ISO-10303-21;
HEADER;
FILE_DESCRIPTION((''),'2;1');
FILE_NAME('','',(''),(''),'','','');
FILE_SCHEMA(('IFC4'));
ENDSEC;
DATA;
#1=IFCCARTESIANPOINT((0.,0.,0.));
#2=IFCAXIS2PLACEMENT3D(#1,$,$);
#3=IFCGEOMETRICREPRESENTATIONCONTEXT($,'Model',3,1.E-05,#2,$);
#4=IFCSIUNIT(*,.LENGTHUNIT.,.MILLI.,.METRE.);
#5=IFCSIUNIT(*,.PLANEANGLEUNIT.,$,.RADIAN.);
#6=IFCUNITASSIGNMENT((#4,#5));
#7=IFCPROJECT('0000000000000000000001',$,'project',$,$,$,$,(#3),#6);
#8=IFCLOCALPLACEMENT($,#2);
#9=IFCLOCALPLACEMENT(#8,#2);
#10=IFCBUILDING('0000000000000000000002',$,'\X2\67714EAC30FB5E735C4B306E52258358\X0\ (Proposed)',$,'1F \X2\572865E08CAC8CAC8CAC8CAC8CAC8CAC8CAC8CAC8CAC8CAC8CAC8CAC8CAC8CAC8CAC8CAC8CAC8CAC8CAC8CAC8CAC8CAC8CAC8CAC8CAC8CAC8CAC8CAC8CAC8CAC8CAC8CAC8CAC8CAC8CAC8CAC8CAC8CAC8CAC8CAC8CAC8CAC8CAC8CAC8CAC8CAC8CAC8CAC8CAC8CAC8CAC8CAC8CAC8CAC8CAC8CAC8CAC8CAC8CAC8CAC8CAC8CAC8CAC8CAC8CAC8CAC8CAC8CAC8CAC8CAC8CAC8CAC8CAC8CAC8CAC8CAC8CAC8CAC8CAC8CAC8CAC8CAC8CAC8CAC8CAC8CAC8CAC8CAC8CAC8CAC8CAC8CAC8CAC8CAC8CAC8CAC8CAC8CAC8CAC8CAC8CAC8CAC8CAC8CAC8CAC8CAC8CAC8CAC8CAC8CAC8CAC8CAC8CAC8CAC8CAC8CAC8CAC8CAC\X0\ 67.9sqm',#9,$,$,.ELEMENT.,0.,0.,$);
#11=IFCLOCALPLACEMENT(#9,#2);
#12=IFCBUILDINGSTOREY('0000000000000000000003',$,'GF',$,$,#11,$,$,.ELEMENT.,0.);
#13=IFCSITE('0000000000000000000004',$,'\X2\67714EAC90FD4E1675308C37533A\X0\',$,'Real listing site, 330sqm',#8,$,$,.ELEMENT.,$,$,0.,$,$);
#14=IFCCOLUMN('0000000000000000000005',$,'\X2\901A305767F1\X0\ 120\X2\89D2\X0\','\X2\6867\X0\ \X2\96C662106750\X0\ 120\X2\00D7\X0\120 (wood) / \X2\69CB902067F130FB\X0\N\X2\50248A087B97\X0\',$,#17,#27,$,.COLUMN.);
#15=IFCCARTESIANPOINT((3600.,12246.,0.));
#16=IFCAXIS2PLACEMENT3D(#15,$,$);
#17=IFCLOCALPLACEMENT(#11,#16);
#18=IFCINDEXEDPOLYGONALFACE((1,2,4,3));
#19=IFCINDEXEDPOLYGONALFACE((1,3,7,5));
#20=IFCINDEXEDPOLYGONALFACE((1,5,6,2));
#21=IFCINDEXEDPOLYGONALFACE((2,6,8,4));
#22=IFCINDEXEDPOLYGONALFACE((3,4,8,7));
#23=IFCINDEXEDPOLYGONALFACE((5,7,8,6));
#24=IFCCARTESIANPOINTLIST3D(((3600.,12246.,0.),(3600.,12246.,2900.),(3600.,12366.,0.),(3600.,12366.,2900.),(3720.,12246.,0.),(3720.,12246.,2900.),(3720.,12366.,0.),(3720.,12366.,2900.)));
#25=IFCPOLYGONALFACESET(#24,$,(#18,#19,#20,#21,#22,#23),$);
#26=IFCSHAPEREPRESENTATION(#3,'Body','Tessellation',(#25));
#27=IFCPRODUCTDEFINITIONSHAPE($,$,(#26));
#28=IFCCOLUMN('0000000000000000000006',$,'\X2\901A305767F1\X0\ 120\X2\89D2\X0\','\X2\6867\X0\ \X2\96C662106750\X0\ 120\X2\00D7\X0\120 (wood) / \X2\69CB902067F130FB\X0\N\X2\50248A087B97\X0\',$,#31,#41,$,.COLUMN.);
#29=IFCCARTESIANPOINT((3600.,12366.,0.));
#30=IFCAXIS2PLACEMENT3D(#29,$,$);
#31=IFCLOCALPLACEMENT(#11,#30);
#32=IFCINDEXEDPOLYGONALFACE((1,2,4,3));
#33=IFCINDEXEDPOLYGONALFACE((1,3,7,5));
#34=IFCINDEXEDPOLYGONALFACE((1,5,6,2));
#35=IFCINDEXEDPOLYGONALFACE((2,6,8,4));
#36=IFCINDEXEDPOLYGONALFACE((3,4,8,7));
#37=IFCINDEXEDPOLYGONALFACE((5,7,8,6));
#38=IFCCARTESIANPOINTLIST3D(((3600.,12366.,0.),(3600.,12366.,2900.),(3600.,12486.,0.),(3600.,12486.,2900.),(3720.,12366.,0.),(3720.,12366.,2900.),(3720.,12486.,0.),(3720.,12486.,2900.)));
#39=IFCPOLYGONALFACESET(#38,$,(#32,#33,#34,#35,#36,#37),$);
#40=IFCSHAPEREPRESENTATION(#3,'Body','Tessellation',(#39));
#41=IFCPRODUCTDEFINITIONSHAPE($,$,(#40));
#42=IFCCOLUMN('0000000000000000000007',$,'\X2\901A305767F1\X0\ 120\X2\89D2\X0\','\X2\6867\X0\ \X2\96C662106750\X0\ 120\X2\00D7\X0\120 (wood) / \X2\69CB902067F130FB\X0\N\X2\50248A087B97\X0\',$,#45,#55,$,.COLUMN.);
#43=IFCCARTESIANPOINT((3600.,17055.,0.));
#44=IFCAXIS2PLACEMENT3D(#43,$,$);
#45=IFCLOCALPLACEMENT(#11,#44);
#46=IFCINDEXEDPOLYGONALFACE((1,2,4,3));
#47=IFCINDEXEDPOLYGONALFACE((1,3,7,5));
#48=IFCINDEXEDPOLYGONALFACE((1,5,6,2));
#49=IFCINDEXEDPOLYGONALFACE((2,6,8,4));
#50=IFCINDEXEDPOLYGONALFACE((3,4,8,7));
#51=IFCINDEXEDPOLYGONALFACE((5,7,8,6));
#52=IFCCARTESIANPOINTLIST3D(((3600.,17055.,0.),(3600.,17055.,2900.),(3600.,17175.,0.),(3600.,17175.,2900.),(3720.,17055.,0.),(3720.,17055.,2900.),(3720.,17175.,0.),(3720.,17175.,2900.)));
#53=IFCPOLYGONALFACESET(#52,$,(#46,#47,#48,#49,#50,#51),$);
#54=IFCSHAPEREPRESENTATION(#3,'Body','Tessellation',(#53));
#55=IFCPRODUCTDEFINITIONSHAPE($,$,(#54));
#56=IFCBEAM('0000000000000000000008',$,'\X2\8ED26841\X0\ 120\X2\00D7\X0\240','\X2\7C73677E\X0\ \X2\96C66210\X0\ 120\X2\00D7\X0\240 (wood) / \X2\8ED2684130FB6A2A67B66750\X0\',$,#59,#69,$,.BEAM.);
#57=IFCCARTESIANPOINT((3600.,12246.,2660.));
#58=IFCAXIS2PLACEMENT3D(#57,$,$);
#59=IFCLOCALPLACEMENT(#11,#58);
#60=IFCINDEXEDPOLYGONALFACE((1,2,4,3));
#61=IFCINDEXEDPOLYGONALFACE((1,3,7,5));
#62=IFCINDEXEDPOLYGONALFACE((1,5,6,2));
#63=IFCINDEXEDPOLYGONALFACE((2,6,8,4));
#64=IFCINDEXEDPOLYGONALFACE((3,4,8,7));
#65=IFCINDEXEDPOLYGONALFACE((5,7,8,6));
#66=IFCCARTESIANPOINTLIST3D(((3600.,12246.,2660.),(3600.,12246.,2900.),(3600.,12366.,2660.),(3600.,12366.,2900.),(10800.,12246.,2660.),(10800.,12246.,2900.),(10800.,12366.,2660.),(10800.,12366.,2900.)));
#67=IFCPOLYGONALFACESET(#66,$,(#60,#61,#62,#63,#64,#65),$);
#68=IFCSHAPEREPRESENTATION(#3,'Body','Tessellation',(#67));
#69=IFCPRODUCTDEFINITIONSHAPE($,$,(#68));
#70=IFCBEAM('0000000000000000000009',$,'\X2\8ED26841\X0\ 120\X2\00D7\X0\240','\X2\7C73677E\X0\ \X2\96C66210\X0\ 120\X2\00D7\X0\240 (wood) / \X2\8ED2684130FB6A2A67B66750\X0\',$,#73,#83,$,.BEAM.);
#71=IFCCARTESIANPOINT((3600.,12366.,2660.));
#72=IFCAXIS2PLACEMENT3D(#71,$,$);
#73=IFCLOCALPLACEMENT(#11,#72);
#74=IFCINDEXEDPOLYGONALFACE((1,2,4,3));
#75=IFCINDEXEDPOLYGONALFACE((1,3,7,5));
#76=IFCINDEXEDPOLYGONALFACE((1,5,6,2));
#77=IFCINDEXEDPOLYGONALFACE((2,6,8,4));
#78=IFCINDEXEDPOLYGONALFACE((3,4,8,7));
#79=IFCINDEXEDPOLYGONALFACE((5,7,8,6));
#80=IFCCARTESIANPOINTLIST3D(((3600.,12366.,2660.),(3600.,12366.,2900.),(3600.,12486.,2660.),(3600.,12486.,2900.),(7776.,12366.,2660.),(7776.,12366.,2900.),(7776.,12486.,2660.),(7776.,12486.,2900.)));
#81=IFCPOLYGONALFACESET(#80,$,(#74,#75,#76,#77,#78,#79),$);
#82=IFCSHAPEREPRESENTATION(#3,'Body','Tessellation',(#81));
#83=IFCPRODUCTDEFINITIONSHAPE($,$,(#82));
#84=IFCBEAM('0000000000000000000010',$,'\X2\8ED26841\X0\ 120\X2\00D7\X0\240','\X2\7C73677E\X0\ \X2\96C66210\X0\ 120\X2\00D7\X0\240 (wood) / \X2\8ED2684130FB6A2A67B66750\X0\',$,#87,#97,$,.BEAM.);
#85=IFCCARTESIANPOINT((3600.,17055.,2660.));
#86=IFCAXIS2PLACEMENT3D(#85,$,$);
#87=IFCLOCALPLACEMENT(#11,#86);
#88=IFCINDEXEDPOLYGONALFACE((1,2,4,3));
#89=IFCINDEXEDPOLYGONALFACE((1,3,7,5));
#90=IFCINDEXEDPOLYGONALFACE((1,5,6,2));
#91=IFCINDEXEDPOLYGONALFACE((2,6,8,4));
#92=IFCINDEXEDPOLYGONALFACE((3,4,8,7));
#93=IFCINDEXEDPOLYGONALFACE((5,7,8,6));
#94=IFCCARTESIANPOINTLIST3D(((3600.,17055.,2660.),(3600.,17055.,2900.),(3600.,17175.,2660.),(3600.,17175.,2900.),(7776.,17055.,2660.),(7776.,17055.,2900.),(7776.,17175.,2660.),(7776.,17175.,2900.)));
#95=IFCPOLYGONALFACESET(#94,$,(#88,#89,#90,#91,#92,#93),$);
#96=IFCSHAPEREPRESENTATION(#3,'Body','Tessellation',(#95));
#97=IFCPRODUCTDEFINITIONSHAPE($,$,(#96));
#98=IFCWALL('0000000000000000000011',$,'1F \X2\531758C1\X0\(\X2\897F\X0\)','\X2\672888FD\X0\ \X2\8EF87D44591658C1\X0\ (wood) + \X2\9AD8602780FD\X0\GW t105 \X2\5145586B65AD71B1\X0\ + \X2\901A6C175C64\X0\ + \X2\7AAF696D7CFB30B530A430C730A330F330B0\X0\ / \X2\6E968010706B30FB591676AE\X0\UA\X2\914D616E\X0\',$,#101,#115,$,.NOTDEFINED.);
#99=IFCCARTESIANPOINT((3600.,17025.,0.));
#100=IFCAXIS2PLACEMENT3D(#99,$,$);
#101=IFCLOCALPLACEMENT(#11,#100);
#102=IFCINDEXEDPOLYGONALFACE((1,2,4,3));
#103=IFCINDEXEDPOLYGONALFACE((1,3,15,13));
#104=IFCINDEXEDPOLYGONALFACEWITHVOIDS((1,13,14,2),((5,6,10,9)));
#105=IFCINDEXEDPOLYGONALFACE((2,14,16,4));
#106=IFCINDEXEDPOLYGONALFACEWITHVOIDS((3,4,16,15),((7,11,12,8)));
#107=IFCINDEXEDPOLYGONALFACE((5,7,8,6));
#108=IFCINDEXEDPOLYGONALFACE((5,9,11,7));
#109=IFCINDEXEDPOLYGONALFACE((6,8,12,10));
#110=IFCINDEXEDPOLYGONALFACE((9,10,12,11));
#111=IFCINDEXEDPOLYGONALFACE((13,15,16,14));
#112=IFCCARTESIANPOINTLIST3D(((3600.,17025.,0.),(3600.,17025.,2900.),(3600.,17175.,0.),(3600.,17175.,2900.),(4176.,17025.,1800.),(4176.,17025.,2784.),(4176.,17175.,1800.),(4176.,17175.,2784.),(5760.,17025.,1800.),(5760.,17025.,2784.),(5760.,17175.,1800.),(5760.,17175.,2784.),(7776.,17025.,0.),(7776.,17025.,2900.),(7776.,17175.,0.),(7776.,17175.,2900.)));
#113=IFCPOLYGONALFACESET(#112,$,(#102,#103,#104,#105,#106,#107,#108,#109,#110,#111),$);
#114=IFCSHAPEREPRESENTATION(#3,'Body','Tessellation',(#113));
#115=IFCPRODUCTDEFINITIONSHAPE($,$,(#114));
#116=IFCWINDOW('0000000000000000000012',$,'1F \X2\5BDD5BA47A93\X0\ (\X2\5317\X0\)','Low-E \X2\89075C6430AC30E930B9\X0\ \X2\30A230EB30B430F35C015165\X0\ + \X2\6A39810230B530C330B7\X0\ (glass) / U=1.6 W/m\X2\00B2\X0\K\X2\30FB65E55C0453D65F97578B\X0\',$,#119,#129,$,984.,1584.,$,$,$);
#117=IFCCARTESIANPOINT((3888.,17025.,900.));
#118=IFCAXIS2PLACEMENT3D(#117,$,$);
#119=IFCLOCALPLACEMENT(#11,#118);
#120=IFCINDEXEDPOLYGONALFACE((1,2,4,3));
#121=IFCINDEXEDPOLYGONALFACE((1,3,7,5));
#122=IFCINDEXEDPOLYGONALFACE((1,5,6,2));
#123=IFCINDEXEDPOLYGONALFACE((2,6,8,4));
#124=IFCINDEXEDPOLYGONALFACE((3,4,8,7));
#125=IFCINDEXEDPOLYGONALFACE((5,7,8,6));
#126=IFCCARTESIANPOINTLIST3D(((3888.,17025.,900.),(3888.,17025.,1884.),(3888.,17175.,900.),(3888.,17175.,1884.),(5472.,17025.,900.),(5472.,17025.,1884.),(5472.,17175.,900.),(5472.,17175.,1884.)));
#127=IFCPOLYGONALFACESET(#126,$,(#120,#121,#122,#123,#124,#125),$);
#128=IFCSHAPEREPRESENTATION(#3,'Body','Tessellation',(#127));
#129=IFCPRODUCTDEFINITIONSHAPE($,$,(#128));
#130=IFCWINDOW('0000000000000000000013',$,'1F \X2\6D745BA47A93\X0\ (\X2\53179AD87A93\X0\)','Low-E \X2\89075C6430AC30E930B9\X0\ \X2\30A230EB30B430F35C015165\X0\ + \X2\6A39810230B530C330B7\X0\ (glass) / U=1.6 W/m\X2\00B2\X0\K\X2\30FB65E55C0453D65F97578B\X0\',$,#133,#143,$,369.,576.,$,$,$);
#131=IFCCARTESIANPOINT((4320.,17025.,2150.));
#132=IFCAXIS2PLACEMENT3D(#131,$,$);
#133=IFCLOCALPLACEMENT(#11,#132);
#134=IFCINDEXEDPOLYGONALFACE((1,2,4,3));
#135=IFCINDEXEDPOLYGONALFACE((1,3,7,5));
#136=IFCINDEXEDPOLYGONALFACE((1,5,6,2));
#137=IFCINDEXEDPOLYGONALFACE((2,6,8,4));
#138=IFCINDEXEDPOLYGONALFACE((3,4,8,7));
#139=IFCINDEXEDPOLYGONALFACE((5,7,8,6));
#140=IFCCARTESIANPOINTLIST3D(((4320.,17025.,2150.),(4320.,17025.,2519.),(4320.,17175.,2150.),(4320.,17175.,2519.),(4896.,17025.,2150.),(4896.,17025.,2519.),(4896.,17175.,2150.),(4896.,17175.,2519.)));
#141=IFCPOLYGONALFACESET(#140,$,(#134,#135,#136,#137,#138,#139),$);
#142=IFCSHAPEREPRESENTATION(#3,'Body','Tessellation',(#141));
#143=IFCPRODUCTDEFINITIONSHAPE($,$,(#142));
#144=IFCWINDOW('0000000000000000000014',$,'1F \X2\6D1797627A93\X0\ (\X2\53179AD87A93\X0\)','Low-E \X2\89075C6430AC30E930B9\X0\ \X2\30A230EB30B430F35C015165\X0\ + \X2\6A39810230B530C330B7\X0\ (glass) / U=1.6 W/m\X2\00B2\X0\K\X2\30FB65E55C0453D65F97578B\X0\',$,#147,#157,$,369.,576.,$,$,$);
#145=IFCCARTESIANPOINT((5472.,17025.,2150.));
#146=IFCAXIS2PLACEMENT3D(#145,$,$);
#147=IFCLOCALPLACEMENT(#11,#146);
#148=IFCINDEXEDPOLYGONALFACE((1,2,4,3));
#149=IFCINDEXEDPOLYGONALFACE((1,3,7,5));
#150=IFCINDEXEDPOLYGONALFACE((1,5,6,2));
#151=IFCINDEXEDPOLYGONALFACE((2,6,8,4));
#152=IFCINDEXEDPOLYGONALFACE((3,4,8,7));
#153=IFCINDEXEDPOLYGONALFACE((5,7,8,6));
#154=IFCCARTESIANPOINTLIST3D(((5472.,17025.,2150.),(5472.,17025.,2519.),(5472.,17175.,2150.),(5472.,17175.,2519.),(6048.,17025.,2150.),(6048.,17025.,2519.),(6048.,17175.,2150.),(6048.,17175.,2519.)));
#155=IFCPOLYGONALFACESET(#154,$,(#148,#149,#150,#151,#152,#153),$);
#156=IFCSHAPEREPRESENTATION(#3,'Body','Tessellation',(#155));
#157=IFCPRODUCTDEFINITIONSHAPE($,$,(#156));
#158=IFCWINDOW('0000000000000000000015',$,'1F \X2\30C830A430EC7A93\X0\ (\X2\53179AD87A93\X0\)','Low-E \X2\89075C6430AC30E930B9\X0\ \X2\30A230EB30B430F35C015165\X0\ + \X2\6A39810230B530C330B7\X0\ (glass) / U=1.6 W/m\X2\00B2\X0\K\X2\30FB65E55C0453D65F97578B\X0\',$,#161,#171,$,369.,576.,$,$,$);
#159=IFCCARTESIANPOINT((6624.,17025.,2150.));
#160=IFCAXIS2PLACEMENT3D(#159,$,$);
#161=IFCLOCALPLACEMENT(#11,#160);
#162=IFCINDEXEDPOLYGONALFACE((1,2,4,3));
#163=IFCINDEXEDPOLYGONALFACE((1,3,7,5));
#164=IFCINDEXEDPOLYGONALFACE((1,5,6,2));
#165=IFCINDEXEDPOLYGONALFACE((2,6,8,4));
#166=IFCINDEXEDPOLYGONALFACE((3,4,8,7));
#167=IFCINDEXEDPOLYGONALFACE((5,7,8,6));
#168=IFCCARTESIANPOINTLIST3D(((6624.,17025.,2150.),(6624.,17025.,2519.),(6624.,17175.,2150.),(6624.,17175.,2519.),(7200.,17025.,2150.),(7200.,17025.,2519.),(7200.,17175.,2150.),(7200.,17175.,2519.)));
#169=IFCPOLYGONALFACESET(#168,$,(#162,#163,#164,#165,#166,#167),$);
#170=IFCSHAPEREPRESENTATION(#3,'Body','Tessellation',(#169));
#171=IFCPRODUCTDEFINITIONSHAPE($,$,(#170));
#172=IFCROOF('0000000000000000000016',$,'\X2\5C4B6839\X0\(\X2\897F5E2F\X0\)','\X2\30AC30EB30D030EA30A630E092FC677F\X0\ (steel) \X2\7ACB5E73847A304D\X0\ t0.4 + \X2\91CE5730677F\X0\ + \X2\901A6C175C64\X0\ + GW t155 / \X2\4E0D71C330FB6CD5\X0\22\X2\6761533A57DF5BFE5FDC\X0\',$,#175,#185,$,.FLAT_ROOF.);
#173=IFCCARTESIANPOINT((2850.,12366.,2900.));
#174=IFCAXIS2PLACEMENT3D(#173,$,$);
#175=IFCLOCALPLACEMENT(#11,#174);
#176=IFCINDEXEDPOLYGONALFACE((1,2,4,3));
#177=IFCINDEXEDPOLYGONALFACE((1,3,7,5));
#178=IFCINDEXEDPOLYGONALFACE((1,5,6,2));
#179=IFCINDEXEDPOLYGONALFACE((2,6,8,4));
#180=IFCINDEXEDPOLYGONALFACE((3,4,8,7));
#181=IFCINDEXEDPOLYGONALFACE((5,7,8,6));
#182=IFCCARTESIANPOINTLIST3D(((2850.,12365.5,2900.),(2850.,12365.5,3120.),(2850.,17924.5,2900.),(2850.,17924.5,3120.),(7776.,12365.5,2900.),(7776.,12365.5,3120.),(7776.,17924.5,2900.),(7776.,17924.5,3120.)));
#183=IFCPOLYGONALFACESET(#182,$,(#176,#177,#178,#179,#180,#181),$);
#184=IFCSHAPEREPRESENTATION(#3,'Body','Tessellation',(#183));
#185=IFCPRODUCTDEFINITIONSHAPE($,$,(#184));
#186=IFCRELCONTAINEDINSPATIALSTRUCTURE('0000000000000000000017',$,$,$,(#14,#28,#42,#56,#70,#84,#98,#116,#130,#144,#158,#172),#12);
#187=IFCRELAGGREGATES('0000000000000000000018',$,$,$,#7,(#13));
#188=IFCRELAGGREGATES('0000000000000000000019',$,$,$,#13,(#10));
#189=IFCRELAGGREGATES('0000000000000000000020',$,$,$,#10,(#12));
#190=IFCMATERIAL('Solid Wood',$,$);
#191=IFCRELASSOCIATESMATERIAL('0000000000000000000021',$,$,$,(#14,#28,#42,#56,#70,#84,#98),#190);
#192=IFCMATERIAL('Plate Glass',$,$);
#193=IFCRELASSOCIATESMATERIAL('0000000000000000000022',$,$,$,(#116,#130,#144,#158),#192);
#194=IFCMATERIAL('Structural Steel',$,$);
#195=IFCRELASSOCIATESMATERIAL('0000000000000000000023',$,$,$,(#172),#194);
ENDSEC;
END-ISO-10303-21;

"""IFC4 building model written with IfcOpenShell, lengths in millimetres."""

from ifc_helpers import new_model, si_unit, frame, frame_2d, origin, place, context, project, spatial, rectangle, extrude, material, element, fill, save


model = new_model("IFC4")

# Units and contexts
model_context = context("Model", 3, precision=1e-05, world=origin())
ifc_project = project(units=[si_unit("LENGTHUNIT", "METRE", prefix="MILLI"), si_unit("PLANEANGLEUNIT", "RADIAN")], contexts=[model_context])

# Site, building, storey
site_placement = place(None, origin())
site = spatial("IfcSite", under=ifc_project, at=site_placement, Name="東京都世田谷区", ObjectType="Real listing site, 330sqm", CompositionType="ELEMENT", RefElevation=0.0)
building_placement = place(site_placement, origin())
building = spatial("IfcBuilding", under=site, at=building_placement, Name="東京・平屋の別荘 (Proposed)", ObjectType="1F 在无責責責責責責責責責責責責責責責責責責責責責責責責責責責責責責責責責責責責責責責責責責責責責責責責責責責責責責責責責責責責責責責責責責責責責責責責責責責責責責責責責責責責責責責責責責責責責責責責責責責責責責責責責責責責責責責責責責責責責責 67.9sqm", CompositionType="ELEMENT", ElevationOfRefHeight=0.0, ElevationOfTerrain=0.0)
storey_placement = place(building_placement, origin())
storey = spatial("IfcBuildingStorey", under=building, at=storey_placement, Name="GF", CompositionType="ELEMENT", Elevation=0.0)

# Columns
ifc_material_1 = material(Name="Solid Wood")
column_1_placement = place(storey_placement, frame((3600.0, 12246.0, 0.0)))
element("IfcColumn", 1, at=column_1_placement, inside=storey, material=ifc_material_1, Name="通し柱 120角", Description="桧 集成材 120×120 (wood) / 構造柱・N値計算", PredefinedType="COLUMN", context=model_context, shape_type="SweptSolid", body=[
    extrude(rectangle(XDim=120.0, YDim=120.0, at=frame_2d((60.0, 60.0))), frame((3600.0, 12246.0, 0.0)), (0.0, 0.0, 1.0), 2900.0),
])
column_2_placement = place(storey_placement, frame((3600.0, 12366.0, 0.0)))
element("IfcColumn", 2, at=column_2_placement, inside=storey, material=ifc_material_1, Name="通し柱 120角", Description="桧 集成材 120×120 (wood) / 構造柱・N値計算", PredefinedType="COLUMN", context=model_context, shape_type="SweptSolid", body=[
    extrude(rectangle(XDim=120.0, YDim=120.0, at=frame_2d((60.0, 60.0))), frame((3600.0, 12366.0, 0.0)), (0.0, 0.0, 1.0), 2900.0),
])
column_3_placement = place(storey_placement, frame((3600.0, 17055.0, 0.0)))
element("IfcColumn", 3, at=column_3_placement, inside=storey, material=ifc_material_1, Name="通し柱 120角", Description="桧 集成材 120×120 (wood) / 構造柱・N値計算", PredefinedType="COLUMN", context=model_context, shape_type="SweptSolid", body=[
    extrude(rectangle(XDim=120.0, YDim=120.0, at=frame_2d((60.0, 60.0))), frame((3600.0, 17055.0, 0.0)), (0.0, 0.0, 1.0), 2900.0),
])

# Beams
beam_1_placement = place(storey_placement, frame((3600.0, 12246.0, 2660.0)))
element("IfcBeam", 4, at=beam_1_placement, inside=storey, material=ifc_material_1, Name="軒桁 120×240", Description="米松 集成 120×240 (wood) / 軒桁・横架材", PredefinedType="BEAM", context=model_context, shape_type="SweptSolid", body=[
    extrude(rectangle(XDim=7200.0, YDim=120.0, at=frame_2d((3600.0, 60.0))), frame((3600.0, 12246.0, 2660.0)), (0.0, 0.0, 1.0), 240.0),
])
beam_2_placement = place(storey_placement, frame((3600.0, 12366.0, 2660.0)))
element("IfcBeam", 5, at=beam_2_placement, inside=storey, material=ifc_material_1, Name="軒桁 120×240", Description="米松 集成 120×240 (wood) / 軒桁・横架材", PredefinedType="BEAM", context=model_context, shape_type="SweptSolid", body=[
    extrude(rectangle(XDim=4176.0, YDim=120.0, at=frame_2d((2088.0, 60.0))), frame((3600.0, 12366.0, 2660.0)), (0.0, 0.0, 1.0), 240.0),
])
beam_3_placement = place(storey_placement, frame((3600.0, 17055.0, 2660.0)))
element("IfcBeam", 6, at=beam_3_placement, inside=storey, material=ifc_material_1, Name="軒桁 120×240", Description="米松 集成 120×240 (wood) / 軒桁・横架材", PredefinedType="BEAM", context=model_context, shape_type="SweptSolid", body=[
    extrude(rectangle(XDim=4176.0, YDim=120.0, at=frame_2d((2088.0, 60.0))), frame((3600.0, 17055.0, 2660.0)), (0.0, 0.0, 1.0), 240.0),
])

# Wall, openings, windows
wall_1_placement = place(storey_placement, frame((3600.0, 17025.0, 0.0)))
wall_1 = element("IfcWall", 7, at=wall_1_placement, inside=storey, material=ifc_material_1, Name="1F 北壁(西)", Description="木製 軸組外壁 (wood) + 高性能GW t105 充填断熱 + 通気層 + 窯業系サイディング / 準耐火・外皮UA配慮", PredefinedType="NOTDEFINED", context=model_context, shape_type="SweptSolid", body=[
    extrude(rectangle(XDim=4176.0, YDim=150.0, at=frame_2d((2088.0, 75.0))), frame((3600.0, 17025.0, 0.0)), (0.0, 0.0, 1.0), 2900.0),
])
opening_1_placement = place(storey_placement, frame((3888.0, 17025.0, 900.0)))
opening_1 = element("IfcOpeningElement", 8, at=opening_1_placement, cuts=wall_1, PredefinedType="NOTDEFINED", context=model_context, shape_type="SweptSolid", body=[
    extrude(rectangle(XDim=1584.0, YDim=150.0, at=frame_2d((792.0, 75.0))), frame((3888.0, 17025.0, 900.0)), (0.0, 0.0, 1.0), 984.0),
])
opening_2_placement = place(storey_placement, frame((4320.0, 17025.0, 2150.0)))
opening_2 = element("IfcOpeningElement", 9, at=opening_2_placement, cuts=wall_1, PredefinedType="NOTDEFINED", context=model_context, shape_type="SweptSolid", body=[
    extrude(rectangle(XDim=576.0, YDim=150.0, at=frame_2d((288.0, 75.0))), frame((4320.0, 17025.0, 2150.0)), (0.0, 0.0, 1.0), 369.0),
])
opening_3_placement = place(storey_placement, frame((5472.0, 17025.0, 2150.0)))
opening_3 = element("IfcOpeningElement", 10, at=opening_3_placement, cuts=wall_1, PredefinedType="NOTDEFINED", context=model_context, shape_type="SweptSolid", body=[
    extrude(rectangle(XDim=576.0, YDim=150.0, at=frame_2d((288.0, 75.0))), frame((5472.0, 17025.0, 2150.0)), (0.0, 0.0, 1.0), 369.0),
])
opening_4_placement = place(storey_placement, frame((6624.0, 17025.0, 2150.0)))
opening_4 = element("IfcOpeningElement", 11, at=opening_4_placement, cuts=wall_1, PredefinedType="NOTDEFINED", context=model_context, shape_type="SweptSolid", body=[
    extrude(rectangle(XDim=576.0, YDim=150.0, at=frame_2d((288.0, 75.0))), frame((6624.0, 17025.0, 2150.0)), (0.0, 0.0, 1.0), 369.0),
])
ifc_material_2 = material(Name="Plate Glass")
window_1_placement = place(storey_placement, frame((3888.0, 17025.0, 900.0)))
window_1 = element("IfcWindow", 12, at=window_1_placement, inside=storey, material=ifc_material_2, Name="1F 寝室窓 (北)", Description="Low-E 複層ガラス アルゴン封入 + 樹脂サッシ (glass) / U=1.6 W/m²K・日射取得型", OverallHeight=984.0, OverallWidth=1584.0, context=model_context, shape_type="SweptSolid", body=[
    extrude(rectangle(XDim=1584.0, YDim=150.0, at=frame_2d((792.0, 75.0))), frame((3888.0, 17025.0, 900.0)), (0.0, 0.0, 1.0), 984.0),
])
fill(opening_1, window_1)
window_2_placement = place(storey_placement, frame((4320.0, 17025.0, 2150.0)))
window_2 = element("IfcWindow", 13, at=window_2_placement, inside=storey, material=ifc_material_2, Name="1F 浴室窓 (北高窓)", Description="Low-E 複層ガラス アルゴン封入 + 樹脂サッシ (glass) / U=1.6 W/m²K・日射取得型", OverallHeight=369.0, OverallWidth=576.0, context=model_context, shape_type="SweptSolid", body=[
    extrude(rectangle(XDim=576.0, YDim=150.0, at=frame_2d((288.0, 75.0))), frame((4320.0, 17025.0, 2150.0)), (0.0, 0.0, 1.0), 369.0),
])
fill(opening_2, window_2)
window_3_placement = place(storey_placement, frame((5472.0, 17025.0, 2150.0)))
window_3 = element("IfcWindow", 14, at=window_3_placement, inside=storey, material=ifc_material_2, Name="1F 洗面窓 (北高窓)", Description="Low-E 複層ガラス アルゴン封入 + 樹脂サッシ (glass) / U=1.6 W/m²K・日射取得型", OverallHeight=369.0, OverallWidth=576.0, context=model_context, shape_type="SweptSolid", body=[
    extrude(rectangle(XDim=576.0, YDim=150.0, at=frame_2d((288.0, 75.0))), frame((5472.0, 17025.0, 2150.0)), (0.0, 0.0, 1.0), 369.0),
])
fill(opening_3, window_3)
window_4_placement = place(storey_placement, frame((6624.0, 17025.0, 2150.0)))
window_4 = element("IfcWindow", 15, at=window_4_placement, inside=storey, material=ifc_material_2, Name="1F トイレ窓 (北高窓)", Description="Low-E 複層ガラス アルゴン封入 + 樹脂サッシ (glass) / U=1.6 W/m²K・日射取得型", OverallHeight=369.0, OverallWidth=576.0, context=model_context, shape_type="SweptSolid", body=[
    extrude(rectangle(XDim=576.0, YDim=150.0, at=frame_2d((288.0, 75.0))), frame((6624.0, 17025.0, 2150.0)), (0.0, 0.0, 1.0), 369.0),
])
fill(opening_4, window_4)

# Roof
ifc_material_3 = material(Name="Structural Steel")
roof_placement = place(storey_placement, frame((2850.0, 12366.0, 2900.0)))
element("IfcRoof", 16, at=roof_placement, inside=storey, material=ifc_material_3, Name="屋根(西帯)", Description="ガルバリウム鋼板 (steel) 立平葺き t0.4 + 野地板 + 通気層 + GW t155 / 不燃・法22条区域対応", PredefinedType="FLAT_ROOF", context=model_context, shape_type="SweptSolid", body=[
    extrude(rectangle(XDim=4926.0, YDim=5559.0, at=frame_2d((2463.0, 2779.0))), frame((2850.0, 12366.0, 2900.0)), (0.0, 0.0, 1.0), 220.0),
])

save(model, "model.ifc")
